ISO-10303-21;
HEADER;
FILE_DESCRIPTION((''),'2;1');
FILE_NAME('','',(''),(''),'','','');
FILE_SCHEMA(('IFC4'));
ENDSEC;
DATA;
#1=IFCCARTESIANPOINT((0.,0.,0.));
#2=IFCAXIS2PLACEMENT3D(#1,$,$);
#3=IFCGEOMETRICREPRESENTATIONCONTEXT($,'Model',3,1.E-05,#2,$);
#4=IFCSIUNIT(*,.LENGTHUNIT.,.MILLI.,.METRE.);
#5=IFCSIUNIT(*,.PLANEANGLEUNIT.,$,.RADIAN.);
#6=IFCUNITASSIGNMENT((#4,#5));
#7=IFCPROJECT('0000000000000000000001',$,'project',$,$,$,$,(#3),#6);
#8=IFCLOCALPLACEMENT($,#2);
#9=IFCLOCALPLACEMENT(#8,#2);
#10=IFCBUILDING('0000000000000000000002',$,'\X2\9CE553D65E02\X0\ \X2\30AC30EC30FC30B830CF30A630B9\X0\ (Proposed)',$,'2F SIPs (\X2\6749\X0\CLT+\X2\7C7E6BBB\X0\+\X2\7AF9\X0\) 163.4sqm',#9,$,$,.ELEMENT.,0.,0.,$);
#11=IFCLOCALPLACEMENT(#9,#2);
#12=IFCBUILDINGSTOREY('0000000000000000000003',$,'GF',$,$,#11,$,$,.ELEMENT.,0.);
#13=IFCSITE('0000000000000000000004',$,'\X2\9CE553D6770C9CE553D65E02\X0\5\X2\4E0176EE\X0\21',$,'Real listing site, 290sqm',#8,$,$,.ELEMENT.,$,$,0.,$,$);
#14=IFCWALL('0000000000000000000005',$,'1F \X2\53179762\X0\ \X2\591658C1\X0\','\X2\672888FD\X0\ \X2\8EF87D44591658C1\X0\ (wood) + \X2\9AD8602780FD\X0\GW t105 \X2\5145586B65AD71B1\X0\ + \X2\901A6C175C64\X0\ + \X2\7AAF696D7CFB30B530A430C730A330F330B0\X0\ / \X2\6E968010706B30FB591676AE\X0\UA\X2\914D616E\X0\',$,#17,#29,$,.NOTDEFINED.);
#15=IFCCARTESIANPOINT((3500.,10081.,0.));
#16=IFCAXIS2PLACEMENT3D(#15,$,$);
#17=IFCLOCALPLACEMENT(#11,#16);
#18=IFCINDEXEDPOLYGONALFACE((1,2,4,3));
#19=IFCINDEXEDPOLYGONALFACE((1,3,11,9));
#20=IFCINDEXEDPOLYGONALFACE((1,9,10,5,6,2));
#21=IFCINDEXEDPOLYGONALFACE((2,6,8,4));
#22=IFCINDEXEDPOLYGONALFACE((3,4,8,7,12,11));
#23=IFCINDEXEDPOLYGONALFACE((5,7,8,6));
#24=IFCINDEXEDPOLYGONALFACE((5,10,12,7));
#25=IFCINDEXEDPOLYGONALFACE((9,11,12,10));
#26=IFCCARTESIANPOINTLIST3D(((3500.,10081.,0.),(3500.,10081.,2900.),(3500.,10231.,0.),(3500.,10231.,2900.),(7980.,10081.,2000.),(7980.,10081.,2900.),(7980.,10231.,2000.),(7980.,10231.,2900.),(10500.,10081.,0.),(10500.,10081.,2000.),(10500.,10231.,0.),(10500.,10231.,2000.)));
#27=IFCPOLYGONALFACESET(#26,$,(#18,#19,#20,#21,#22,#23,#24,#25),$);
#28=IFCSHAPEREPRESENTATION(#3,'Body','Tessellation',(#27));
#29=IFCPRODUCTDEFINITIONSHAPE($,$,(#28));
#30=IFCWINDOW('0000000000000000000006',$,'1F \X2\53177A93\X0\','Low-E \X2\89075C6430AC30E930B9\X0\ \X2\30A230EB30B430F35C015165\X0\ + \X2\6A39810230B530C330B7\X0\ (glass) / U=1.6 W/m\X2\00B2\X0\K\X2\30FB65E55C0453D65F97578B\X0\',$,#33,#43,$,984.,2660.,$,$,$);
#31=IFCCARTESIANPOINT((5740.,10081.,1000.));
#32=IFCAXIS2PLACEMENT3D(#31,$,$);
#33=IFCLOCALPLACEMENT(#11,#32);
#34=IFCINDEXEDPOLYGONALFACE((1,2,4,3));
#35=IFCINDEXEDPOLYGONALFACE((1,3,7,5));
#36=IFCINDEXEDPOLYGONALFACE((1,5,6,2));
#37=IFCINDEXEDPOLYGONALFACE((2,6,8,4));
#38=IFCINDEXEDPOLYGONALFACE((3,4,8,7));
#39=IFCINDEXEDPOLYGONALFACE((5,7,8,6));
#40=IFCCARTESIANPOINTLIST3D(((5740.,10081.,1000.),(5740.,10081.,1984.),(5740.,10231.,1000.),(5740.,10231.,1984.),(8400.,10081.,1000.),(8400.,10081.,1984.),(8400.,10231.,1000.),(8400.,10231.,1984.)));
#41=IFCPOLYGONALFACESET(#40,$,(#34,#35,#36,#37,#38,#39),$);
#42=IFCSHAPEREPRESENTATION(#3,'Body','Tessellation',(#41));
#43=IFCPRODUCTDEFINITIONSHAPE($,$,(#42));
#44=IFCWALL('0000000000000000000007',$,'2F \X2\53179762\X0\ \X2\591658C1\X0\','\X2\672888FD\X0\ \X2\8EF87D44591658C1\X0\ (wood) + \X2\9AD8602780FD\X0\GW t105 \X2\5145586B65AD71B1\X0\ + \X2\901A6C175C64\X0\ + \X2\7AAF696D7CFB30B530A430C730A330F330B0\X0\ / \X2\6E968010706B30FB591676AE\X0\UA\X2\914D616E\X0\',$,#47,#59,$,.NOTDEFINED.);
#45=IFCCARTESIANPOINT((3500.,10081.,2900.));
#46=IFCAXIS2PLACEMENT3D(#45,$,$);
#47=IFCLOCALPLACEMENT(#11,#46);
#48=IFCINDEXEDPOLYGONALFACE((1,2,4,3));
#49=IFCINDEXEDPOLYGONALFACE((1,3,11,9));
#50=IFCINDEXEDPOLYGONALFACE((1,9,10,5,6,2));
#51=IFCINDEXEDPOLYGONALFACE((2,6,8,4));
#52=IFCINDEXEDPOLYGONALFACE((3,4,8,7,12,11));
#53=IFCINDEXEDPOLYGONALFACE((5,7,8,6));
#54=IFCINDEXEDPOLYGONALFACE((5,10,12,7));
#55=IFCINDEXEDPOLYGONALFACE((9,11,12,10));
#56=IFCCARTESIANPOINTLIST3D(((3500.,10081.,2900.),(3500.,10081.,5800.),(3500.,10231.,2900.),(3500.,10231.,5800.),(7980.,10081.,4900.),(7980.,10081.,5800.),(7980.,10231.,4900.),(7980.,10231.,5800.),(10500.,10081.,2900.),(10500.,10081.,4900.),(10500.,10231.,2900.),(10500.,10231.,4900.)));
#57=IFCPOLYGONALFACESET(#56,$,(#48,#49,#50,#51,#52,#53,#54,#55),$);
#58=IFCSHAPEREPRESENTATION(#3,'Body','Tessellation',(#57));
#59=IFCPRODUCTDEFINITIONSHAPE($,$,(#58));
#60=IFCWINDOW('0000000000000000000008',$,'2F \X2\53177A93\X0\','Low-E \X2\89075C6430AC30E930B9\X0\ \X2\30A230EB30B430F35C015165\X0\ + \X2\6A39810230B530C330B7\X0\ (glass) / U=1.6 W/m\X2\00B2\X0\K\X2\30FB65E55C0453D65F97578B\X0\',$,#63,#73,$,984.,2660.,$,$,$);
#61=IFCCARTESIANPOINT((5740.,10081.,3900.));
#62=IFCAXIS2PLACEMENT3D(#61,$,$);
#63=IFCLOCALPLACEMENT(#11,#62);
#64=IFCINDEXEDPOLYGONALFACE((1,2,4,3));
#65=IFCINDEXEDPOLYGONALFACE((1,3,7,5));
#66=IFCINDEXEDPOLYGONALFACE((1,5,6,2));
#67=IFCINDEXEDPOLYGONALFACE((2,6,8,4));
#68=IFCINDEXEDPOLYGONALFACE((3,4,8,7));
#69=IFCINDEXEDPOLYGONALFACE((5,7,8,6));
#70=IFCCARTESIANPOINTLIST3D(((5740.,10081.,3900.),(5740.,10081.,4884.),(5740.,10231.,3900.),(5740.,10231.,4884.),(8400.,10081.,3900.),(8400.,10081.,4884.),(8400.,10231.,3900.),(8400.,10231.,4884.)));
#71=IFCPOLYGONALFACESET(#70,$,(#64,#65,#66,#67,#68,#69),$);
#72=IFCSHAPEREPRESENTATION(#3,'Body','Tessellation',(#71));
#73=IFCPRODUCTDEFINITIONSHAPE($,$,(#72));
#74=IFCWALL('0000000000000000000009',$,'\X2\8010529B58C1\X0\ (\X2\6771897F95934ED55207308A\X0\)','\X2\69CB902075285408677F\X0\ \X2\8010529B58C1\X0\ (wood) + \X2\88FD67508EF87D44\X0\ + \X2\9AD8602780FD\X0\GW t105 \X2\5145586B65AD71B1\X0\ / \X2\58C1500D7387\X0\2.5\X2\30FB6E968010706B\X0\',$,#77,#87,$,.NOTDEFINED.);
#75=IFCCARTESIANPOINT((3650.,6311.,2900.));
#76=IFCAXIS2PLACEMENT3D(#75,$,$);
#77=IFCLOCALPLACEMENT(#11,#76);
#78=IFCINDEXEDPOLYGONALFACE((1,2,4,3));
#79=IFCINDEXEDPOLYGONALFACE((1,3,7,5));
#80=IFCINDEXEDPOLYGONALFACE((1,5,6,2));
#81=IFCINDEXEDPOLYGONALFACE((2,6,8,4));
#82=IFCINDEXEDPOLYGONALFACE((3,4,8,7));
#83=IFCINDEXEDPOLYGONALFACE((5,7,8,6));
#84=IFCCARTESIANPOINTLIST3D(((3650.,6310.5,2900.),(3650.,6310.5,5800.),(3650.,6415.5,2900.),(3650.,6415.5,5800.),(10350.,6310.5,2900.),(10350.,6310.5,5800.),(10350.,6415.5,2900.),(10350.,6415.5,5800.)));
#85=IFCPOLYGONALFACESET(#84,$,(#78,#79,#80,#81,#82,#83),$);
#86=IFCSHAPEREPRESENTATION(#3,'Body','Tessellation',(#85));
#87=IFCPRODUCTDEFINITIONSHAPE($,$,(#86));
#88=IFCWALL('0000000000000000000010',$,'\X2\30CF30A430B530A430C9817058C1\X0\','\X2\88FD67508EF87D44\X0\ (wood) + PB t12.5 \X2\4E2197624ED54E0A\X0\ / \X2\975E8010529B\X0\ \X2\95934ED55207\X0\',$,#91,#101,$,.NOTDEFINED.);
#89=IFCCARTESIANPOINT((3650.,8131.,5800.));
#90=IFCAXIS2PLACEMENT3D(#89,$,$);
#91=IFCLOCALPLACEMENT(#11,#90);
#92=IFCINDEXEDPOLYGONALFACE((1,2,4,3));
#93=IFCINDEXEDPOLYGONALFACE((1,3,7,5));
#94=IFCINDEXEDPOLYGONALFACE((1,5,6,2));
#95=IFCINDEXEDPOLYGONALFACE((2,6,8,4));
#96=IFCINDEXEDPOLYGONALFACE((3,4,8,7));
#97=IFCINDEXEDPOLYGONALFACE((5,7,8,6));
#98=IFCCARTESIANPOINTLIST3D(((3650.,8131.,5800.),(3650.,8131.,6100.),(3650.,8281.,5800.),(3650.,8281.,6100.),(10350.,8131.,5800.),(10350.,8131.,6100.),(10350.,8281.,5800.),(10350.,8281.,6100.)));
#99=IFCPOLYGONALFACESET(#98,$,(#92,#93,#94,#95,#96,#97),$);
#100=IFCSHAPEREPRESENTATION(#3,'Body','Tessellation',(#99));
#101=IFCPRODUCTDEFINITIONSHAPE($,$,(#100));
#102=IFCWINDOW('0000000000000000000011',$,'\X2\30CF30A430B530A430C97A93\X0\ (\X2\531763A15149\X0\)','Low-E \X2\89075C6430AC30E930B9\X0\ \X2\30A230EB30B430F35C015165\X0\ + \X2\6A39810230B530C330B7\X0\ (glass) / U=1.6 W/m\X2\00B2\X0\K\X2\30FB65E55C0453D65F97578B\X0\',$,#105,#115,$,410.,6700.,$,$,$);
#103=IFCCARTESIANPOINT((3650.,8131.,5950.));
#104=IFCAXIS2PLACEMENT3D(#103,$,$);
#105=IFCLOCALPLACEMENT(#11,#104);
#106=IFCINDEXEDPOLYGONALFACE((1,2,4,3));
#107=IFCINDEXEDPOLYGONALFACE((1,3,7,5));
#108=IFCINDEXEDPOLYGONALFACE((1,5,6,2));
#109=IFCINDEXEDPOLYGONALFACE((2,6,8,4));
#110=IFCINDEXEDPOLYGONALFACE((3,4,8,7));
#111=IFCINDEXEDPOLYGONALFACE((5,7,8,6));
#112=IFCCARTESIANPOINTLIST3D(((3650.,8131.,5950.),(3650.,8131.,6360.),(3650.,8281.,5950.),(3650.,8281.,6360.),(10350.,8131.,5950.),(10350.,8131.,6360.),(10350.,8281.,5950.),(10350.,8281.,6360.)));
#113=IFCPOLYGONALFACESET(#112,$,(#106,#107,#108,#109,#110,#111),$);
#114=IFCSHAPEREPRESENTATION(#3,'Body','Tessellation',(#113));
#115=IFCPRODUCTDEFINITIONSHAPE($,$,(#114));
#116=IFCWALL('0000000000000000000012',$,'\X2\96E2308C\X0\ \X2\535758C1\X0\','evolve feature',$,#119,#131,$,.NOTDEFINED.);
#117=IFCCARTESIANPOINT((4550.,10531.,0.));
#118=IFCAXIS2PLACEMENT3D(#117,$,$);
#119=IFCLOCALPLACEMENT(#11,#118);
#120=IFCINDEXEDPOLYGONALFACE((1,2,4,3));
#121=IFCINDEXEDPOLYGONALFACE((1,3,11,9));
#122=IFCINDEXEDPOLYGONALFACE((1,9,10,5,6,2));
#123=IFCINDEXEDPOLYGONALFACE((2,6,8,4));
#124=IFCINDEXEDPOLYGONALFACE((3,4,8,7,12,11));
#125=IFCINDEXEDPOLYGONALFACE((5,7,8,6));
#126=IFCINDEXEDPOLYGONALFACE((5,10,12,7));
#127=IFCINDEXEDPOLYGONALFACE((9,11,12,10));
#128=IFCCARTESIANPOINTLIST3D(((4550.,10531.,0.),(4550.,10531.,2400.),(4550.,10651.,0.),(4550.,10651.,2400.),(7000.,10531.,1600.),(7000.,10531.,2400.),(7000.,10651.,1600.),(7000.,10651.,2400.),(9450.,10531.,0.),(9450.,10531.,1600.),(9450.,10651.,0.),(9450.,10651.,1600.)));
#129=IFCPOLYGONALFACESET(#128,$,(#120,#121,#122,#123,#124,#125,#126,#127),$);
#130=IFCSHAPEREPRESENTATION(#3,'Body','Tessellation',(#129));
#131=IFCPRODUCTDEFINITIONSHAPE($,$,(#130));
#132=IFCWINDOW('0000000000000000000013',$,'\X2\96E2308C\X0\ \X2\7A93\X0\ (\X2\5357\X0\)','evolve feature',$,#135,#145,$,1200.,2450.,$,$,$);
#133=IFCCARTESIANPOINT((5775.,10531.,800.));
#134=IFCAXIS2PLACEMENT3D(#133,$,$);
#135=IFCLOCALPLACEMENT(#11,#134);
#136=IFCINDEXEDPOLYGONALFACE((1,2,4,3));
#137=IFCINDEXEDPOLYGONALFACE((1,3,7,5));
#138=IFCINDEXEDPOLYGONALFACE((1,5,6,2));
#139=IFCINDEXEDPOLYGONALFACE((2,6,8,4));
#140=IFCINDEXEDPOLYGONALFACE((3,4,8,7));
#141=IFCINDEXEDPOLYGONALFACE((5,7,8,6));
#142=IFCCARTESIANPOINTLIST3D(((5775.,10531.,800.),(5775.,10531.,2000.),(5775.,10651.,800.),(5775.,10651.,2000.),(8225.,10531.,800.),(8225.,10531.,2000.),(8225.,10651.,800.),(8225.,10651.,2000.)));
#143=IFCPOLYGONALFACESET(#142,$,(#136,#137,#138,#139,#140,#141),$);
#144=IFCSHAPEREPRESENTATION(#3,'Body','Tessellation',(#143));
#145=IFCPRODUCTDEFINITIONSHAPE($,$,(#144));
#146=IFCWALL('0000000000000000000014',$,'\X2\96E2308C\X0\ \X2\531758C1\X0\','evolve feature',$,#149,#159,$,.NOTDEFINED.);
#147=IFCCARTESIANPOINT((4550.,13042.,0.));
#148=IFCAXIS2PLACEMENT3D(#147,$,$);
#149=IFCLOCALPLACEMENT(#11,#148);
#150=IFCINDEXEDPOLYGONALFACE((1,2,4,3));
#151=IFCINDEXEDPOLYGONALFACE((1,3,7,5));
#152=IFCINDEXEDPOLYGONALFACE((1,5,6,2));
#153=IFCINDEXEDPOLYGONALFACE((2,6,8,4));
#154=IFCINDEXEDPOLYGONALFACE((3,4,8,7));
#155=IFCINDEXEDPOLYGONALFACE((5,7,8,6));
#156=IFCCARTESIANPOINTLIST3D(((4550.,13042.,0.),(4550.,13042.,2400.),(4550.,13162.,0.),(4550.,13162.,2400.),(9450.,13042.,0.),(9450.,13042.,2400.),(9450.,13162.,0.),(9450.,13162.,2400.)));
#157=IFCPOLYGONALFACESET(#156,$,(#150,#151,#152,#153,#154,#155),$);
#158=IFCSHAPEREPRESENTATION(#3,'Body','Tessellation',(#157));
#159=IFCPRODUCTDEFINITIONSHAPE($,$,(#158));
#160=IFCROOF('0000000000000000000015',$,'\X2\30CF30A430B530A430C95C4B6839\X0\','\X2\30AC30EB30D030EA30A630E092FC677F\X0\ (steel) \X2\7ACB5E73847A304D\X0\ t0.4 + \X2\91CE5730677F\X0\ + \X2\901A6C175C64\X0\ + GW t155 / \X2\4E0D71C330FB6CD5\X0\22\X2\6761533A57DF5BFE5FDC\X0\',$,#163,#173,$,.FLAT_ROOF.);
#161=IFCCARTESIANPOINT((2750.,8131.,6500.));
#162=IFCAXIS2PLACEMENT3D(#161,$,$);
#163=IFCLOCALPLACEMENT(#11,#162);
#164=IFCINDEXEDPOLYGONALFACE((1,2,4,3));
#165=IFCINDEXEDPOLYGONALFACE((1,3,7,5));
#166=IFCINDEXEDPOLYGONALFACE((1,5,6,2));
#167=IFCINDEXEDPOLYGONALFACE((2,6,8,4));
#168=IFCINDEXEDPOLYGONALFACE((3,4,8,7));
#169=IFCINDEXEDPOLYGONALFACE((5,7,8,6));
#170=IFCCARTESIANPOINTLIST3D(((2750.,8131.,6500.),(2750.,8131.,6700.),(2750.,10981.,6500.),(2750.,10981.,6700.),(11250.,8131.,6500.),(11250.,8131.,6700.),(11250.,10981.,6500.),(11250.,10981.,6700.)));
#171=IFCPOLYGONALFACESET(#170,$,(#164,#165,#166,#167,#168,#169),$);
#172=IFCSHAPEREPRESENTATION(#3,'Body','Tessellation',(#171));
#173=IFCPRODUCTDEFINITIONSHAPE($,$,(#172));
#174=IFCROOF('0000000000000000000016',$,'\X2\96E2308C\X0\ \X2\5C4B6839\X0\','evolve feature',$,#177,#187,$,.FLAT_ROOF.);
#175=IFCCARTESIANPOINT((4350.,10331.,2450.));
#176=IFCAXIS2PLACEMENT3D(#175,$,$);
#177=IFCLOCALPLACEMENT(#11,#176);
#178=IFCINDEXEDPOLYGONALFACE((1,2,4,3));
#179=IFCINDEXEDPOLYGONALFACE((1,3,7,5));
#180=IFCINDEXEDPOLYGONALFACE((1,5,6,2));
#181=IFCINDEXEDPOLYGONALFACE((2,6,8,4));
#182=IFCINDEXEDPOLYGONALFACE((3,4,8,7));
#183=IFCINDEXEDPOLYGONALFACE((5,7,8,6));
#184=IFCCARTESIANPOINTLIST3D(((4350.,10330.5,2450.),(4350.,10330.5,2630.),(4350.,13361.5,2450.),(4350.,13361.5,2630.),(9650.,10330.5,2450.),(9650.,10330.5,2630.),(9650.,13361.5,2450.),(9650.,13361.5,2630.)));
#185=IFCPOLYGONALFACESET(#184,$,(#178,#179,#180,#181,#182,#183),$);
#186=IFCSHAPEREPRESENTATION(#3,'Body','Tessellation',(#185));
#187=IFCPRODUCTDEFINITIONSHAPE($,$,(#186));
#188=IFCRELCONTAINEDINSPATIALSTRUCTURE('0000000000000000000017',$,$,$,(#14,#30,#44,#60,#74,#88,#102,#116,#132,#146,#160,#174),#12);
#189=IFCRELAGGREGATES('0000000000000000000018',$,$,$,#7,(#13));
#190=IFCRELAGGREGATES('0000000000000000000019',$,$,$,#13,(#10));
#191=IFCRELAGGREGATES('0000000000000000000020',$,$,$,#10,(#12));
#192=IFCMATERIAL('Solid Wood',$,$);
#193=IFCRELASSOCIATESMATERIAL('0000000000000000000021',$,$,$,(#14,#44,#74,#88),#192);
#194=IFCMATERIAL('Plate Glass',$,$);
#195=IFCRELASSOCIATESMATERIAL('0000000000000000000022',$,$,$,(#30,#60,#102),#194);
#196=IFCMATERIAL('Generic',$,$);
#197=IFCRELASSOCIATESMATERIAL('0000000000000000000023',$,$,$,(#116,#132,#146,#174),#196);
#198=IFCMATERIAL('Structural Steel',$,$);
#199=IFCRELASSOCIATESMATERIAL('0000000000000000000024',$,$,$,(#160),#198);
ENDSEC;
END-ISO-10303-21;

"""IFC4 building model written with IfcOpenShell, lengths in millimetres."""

from ifc_helpers import new_model, si_unit, frame, frame_2d, origin, place, context, project, spatial, rectangle, extrude, material, element, fill, save


model = new_model("IFC4")

# Units and contexts
model_context = context("Model", 3, precision=1e-05, world=origin())
ifc_project = project(units=[si_unit("LENGTHUNIT", "METRE", prefix="MILLI"), si_unit("PLANEANGLEUNIT", "RADIAN")], contexts=[model_context])

# Site, building, storey
site_placement = place(None, origin())
site = spatial("IfcSite", under=ifc_project, at=site_placement, Name="鳥取県鳥取市5丁目21", ObjectType="Real listing site, 290sqm", CompositionType="ELEMENT", RefElevation=0.0)
building_placement = place(site_placement, origin())
building = spatial("IfcBuilding", under=site, at=building_placement, Name="鳥取市 ガレージハウス (Proposed)", ObjectType="2F SIPs (杉CLT+籾殻+竹) 163.4sqm", CompositionType="ELEMENT", ElevationOfRefHeight=0.0, ElevationOfTerrain=0.0)
storey_placement = place(building_placement, origin())
storey = spatial("IfcBuildingStorey", under=building, at=storey_placement, Name="GF", CompositionType="ELEMENT", Elevation=0.0)

# Shared definitions
ifc_material_1 = material(Name="Generic")

# Wall, opening, window
ifc_material_2 = material(Name="Solid Wood")
wall_1_placement = place(storey_placement, frame((3500.0, 10081.0, 0.0)))
wall_1 = element("IfcWall", 1, at=wall_1_placement, inside=storey, material=ifc_material_2, Name="1F 北面 外壁", Description="木製 軸組外壁 (wood) + 高性能GW t105 充填断熱 + 通気層 + 窯業系サイディング / 準耐火・外皮UA配慮", PredefinedType="NOTDEFINED", context=model_context, shape_type="SweptSolid", body=[
    extrude(rectangle(XDim=7000.0, YDim=150.0, at=frame_2d((3500.0, 75.0))), frame((3500.0, 10081.0, 0.0)), (0.0, 0.0, 1.0), 2900.0),
])
opening_1_placement = place(storey_placement, frame((5740.0, 10081.0, 1000.0)))
opening_1 = element("IfcOpeningElement", 2, at=opening_1_placement, cuts=wall_1, PredefinedType="NOTDEFINED", context=model_context, shape_type="SweptSolid", body=[
    extrude(rectangle(XDim=2660.0, YDim=150.0, at=frame_2d((1330.0, 75.0))), frame((5740.0, 10081.0, 1000.0)), (0.0, 0.0, 1.0), 984.0),
])
ifc_material_3 = material(Name="Plate Glass")
window_1_placement = place(storey_placement, frame((5740.0, 10081.0, 1000.0)))
window_1 = element("IfcWindow", 3, at=window_1_placement, inside=storey, material=ifc_material_3, Name="1F 北窓", Description="Low-E 複層ガラス アルゴン封入 + 樹脂サッシ (glass) / U=1.6 W/m²K・日射取得型", OverallHeight=984.0, OverallWidth=2660.0, context=model_context, shape_type="SweptSolid", body=[
    extrude(rectangle(XDim=2660.0, YDim=150.0, at=frame_2d((1330.0, 75.0))), frame((5740.0, 10081.0, 1000.0)), (0.0, 0.0, 1.0), 984.0),
])
fill(opening_1, window_1)

# Wall, opening, window
wall_2_placement = place(storey_placement, frame((3500.0, 10081.0, 2900.0)))
wall_2 = element("IfcWall", 4, at=wall_2_placement, inside=storey, material=ifc_material_2, Name="2F 北面 外壁", Description="木製 軸組外壁 (wood) + 高性能GW t105 充填断熱 + 通気層 + 窯業系サイディング / 準耐火・外皮UA配慮", PredefinedType="NOTDEFINED", context=model_context, shape_type="SweptSolid", body=[
    extrude(rectangle(XDim=7000.0, YDim=150.0, at=frame_2d((3500.0, 75.0))), frame((3500.0, 10081.0, 2900.0)), (0.0, 0.0, 1.0), 2900.0),
])
opening_2_placement = place(storey_placement, frame((5740.0, 10081.0, 3900.0)))
opening_2 = element("IfcOpeningElement", 5, at=opening_2_placement, cuts=wall_2, PredefinedType="NOTDEFINED", context=model_context, shape_type="SweptSolid", body=[
    extrude(rectangle(XDim=2660.0, YDim=150.0, at=frame_2d((1330.0, 75.0))), frame((5740.0, 10081.0, 3900.0)), (0.0, 0.0, 1.0), 984.0),
])
window_2_placement = place(storey_placement, frame((5740.0, 10081.0, 3900.0)))
window_2 = element("IfcWindow", 6, at=window_2_placement, inside=storey, material=ifc_material_3, Name="2F 北窓", Description="Low-E 複層ガラス アルゴン封入 + 樹脂サッシ (glass) / U=1.6 W/m²K・日射取得型", OverallHeight=984.0, OverallWidth=2660.0, context=model_context, shape_type="SweptSolid", body=[
    extrude(rectangle(XDim=2660.0, YDim=150.0, at=frame_2d((1330.0, 75.0))), frame((5740.0, 10081.0, 3900.0)), (0.0, 0.0, 1.0), 984.0),
])
fill(opening_2, window_2)

# Wall
wall_3_placement = place(storey_placement, frame((3650.0, 6311.0, 2900.0)))
element("IfcWall", 7, at=wall_3_placement, inside=storey, material=ifc_material_2, Name="耐力壁 (東西間仕切り)", Description="構造用合板 耐力壁 (wood) + 製材軸組 + 高性能GW t105 充填断熱 / 壁倍率2.5・準耐火", PredefinedType="NOTDEFINED", context=model_context, shape_type="SweptSolid", body=[
    extrude(rectangle(XDim=6700.0, YDim=105.0, at=frame_2d((3350.0, 52.0))), frame((3650.0, 6311.0, 2900.0)), (0.0, 0.0, 1.0), 2900.0),
])

# Walls, openings, windows
wall_4_placement = place(storey_placement, frame((3650.0, 8131.0, 5800.0)))
wall_4 = element("IfcWall", 8, at=wall_4_placement, inside=storey, material=ifc_material_2, Name="ハイサイド腰壁", Description="製材軸組 (wood) + PB t12.5 両面仕上 / 非耐力 間仕切", PredefinedType="NOTDEFINED", context=model_context, shape_type="SweptSolid", body=[
    extrude(rectangle(XDim=6700.0, YDim=150.0, at=frame_2d((3350.0, 75.0))), frame((3650.0, 8131.0, 5800.0)), (0.0, 0.0, 1.0), 700.0),
])
opening_3_placement = place(storey_placement, frame((3650.0, 8131.0, 5950.0)))
opening_3 = element("IfcOpeningElement", 9, at=opening_3_placement, cuts=wall_4, PredefinedType="NOTDEFINED", context=model_context, shape_type="SweptSolid", body=[
    extrude(rectangle(XDim=6700.0, YDim=150.0, at=frame_2d((3350.0, 75.0))), frame((3650.0, 8131.0, 5950.0)), (0.0, 0.0, 1.0), 410.0),
])
window_3_placement = place(storey_placement, frame((3650.0, 8131.0, 5950.0)))
window_3 = element("IfcWindow", 10, at=window_3_placement, inside=storey, material=ifc_material_3, Name="ハイサイド窓 (北採光)", Description="Low-E 複層ガラス アルゴン封入 + 樹脂サッシ (glass) / U=1.6 W/m²K・日射取得型", OverallHeight=410.0, OverallWidth=6700.0, context=model_context, shape_type="SweptSolid", body=[
    extrude(rectangle(XDim=6700.0, YDim=150.0, at=frame_2d((3350.0, 75.0))), frame((3650.0, 8131.0, 5950.0)), (0.0, 0.0, 1.0), 410.0),
])
fill(opening_3, window_3)
wall_5_placement = place(storey_placement, frame((4550.0, 10531.0, 0.0)))
wall_5 = element("IfcWall", 11, at=wall_5_placement, inside=storey, material=ifc_material_1, Name="離れ 南壁", Description="evolve feature", PredefinedType="NOTDEFINED", context=model_context, shape_type="SweptSolid", body=[
    extrude(rectangle(XDim=4900.0, YDim=120.0, at=frame_2d((2450.0, 60.0))), frame((4550.0, 10531.0, 0.0)), (0.0, 0.0, 1.0), 2400.0),
])
opening_4_placement = place(storey_placement, frame((5775.0, 10531.0, 800.0)))
opening_4 = element("IfcOpeningElement", 12, at=opening_4_placement, cuts=wall_5, PredefinedType="NOTDEFINED", context=model_context, shape_type="SweptSolid", body=[
    extrude(rectangle(XDim=2450.0, YDim=120.0, at=frame_2d((1225.0, 60.0))), frame((5775.0, 10531.0, 800.0)), (0.0, 0.0, 1.0), 1200.0),
])
window_4_placement = place(storey_placement, frame((5775.0, 10531.0, 800.0)))
window_4 = element("IfcWindow", 13, at=window_4_placement, inside=storey, material=ifc_material_1, Name="離れ 窓 (南)", Description="evolve feature", OverallHeight=1200.0, OverallWidth=2450.0, context=model_context, shape_type="SweptSolid", body=[
    extrude(rectangle(XDim=2450.0, YDim=120.0, at=frame_2d((1225.0, 60.0))), frame((5775.0, 10531.0, 800.0)), (0.0, 0.0, 1.0), 1200.0),
])
fill(opening_4, window_4)

# Wall
wall_6_placement = place(storey_placement, frame((4550.0, 13042.0, 0.0)))
element("IfcWall", 14, at=wall_6_placement, inside=storey, material=ifc_material_1, Name="離れ 北壁", Description="evolve feature", PredefinedType="NOTDEFINED", context=model_context, shape_type="SweptSolid", body=[
    extrude(rectangle(XDim=4900.0, YDim=120.0, at=frame_2d((2450.0, 60.0))), frame((4550.0, 13042.0, 0.0)), (0.0, 0.0, 1.0), 2400.0),
])

# Roofs
ifc_material_4 = material(Name="Structural Steel")
roof_1_placement = place(storey_placement, frame((2750.0, 8131.0, 6500.0)))
element("IfcRoof", 15, at=roof_1_placement, inside=storey, material=ifc_material_4, Name="ハイサイド屋根", Description="ガルバリウム鋼板 (steel) 立平葺き t0.4 + 野地板 + 通気層 + GW t155 / 不燃・法22条区域対応", PredefinedType="FLAT_ROOF", context=model_context, shape_type="SweptSolid", body=[
    extrude(rectangle(XDim=8500.0, YDim=2850.0, at=frame_2d((4250.0, 1425.0))), frame((2750.0, 8131.0, 6500.0)), (0.0, 0.0, 1.0), 200.0),
])
roof_2_placement = place(storey_placement, frame((4350.0, 10331.0, 2450.0)))
element("IfcRoof", 16, at=roof_2_placement, inside=storey, material=ifc_material_1, Name="離れ 屋根", Description="evolve feature", PredefinedType="FLAT_ROOF", context=model_context, shape_type="SweptSolid", body=[
    extrude(rectangle(XDim=5300.0, YDim=3031.0, at=frame_2d((2650.0, 1515.0))), frame((4350.0, 10331.0, 2450.0)), (0.0, 0.0, 1.0), 180.0),
])

save(model, "model.ifc")
